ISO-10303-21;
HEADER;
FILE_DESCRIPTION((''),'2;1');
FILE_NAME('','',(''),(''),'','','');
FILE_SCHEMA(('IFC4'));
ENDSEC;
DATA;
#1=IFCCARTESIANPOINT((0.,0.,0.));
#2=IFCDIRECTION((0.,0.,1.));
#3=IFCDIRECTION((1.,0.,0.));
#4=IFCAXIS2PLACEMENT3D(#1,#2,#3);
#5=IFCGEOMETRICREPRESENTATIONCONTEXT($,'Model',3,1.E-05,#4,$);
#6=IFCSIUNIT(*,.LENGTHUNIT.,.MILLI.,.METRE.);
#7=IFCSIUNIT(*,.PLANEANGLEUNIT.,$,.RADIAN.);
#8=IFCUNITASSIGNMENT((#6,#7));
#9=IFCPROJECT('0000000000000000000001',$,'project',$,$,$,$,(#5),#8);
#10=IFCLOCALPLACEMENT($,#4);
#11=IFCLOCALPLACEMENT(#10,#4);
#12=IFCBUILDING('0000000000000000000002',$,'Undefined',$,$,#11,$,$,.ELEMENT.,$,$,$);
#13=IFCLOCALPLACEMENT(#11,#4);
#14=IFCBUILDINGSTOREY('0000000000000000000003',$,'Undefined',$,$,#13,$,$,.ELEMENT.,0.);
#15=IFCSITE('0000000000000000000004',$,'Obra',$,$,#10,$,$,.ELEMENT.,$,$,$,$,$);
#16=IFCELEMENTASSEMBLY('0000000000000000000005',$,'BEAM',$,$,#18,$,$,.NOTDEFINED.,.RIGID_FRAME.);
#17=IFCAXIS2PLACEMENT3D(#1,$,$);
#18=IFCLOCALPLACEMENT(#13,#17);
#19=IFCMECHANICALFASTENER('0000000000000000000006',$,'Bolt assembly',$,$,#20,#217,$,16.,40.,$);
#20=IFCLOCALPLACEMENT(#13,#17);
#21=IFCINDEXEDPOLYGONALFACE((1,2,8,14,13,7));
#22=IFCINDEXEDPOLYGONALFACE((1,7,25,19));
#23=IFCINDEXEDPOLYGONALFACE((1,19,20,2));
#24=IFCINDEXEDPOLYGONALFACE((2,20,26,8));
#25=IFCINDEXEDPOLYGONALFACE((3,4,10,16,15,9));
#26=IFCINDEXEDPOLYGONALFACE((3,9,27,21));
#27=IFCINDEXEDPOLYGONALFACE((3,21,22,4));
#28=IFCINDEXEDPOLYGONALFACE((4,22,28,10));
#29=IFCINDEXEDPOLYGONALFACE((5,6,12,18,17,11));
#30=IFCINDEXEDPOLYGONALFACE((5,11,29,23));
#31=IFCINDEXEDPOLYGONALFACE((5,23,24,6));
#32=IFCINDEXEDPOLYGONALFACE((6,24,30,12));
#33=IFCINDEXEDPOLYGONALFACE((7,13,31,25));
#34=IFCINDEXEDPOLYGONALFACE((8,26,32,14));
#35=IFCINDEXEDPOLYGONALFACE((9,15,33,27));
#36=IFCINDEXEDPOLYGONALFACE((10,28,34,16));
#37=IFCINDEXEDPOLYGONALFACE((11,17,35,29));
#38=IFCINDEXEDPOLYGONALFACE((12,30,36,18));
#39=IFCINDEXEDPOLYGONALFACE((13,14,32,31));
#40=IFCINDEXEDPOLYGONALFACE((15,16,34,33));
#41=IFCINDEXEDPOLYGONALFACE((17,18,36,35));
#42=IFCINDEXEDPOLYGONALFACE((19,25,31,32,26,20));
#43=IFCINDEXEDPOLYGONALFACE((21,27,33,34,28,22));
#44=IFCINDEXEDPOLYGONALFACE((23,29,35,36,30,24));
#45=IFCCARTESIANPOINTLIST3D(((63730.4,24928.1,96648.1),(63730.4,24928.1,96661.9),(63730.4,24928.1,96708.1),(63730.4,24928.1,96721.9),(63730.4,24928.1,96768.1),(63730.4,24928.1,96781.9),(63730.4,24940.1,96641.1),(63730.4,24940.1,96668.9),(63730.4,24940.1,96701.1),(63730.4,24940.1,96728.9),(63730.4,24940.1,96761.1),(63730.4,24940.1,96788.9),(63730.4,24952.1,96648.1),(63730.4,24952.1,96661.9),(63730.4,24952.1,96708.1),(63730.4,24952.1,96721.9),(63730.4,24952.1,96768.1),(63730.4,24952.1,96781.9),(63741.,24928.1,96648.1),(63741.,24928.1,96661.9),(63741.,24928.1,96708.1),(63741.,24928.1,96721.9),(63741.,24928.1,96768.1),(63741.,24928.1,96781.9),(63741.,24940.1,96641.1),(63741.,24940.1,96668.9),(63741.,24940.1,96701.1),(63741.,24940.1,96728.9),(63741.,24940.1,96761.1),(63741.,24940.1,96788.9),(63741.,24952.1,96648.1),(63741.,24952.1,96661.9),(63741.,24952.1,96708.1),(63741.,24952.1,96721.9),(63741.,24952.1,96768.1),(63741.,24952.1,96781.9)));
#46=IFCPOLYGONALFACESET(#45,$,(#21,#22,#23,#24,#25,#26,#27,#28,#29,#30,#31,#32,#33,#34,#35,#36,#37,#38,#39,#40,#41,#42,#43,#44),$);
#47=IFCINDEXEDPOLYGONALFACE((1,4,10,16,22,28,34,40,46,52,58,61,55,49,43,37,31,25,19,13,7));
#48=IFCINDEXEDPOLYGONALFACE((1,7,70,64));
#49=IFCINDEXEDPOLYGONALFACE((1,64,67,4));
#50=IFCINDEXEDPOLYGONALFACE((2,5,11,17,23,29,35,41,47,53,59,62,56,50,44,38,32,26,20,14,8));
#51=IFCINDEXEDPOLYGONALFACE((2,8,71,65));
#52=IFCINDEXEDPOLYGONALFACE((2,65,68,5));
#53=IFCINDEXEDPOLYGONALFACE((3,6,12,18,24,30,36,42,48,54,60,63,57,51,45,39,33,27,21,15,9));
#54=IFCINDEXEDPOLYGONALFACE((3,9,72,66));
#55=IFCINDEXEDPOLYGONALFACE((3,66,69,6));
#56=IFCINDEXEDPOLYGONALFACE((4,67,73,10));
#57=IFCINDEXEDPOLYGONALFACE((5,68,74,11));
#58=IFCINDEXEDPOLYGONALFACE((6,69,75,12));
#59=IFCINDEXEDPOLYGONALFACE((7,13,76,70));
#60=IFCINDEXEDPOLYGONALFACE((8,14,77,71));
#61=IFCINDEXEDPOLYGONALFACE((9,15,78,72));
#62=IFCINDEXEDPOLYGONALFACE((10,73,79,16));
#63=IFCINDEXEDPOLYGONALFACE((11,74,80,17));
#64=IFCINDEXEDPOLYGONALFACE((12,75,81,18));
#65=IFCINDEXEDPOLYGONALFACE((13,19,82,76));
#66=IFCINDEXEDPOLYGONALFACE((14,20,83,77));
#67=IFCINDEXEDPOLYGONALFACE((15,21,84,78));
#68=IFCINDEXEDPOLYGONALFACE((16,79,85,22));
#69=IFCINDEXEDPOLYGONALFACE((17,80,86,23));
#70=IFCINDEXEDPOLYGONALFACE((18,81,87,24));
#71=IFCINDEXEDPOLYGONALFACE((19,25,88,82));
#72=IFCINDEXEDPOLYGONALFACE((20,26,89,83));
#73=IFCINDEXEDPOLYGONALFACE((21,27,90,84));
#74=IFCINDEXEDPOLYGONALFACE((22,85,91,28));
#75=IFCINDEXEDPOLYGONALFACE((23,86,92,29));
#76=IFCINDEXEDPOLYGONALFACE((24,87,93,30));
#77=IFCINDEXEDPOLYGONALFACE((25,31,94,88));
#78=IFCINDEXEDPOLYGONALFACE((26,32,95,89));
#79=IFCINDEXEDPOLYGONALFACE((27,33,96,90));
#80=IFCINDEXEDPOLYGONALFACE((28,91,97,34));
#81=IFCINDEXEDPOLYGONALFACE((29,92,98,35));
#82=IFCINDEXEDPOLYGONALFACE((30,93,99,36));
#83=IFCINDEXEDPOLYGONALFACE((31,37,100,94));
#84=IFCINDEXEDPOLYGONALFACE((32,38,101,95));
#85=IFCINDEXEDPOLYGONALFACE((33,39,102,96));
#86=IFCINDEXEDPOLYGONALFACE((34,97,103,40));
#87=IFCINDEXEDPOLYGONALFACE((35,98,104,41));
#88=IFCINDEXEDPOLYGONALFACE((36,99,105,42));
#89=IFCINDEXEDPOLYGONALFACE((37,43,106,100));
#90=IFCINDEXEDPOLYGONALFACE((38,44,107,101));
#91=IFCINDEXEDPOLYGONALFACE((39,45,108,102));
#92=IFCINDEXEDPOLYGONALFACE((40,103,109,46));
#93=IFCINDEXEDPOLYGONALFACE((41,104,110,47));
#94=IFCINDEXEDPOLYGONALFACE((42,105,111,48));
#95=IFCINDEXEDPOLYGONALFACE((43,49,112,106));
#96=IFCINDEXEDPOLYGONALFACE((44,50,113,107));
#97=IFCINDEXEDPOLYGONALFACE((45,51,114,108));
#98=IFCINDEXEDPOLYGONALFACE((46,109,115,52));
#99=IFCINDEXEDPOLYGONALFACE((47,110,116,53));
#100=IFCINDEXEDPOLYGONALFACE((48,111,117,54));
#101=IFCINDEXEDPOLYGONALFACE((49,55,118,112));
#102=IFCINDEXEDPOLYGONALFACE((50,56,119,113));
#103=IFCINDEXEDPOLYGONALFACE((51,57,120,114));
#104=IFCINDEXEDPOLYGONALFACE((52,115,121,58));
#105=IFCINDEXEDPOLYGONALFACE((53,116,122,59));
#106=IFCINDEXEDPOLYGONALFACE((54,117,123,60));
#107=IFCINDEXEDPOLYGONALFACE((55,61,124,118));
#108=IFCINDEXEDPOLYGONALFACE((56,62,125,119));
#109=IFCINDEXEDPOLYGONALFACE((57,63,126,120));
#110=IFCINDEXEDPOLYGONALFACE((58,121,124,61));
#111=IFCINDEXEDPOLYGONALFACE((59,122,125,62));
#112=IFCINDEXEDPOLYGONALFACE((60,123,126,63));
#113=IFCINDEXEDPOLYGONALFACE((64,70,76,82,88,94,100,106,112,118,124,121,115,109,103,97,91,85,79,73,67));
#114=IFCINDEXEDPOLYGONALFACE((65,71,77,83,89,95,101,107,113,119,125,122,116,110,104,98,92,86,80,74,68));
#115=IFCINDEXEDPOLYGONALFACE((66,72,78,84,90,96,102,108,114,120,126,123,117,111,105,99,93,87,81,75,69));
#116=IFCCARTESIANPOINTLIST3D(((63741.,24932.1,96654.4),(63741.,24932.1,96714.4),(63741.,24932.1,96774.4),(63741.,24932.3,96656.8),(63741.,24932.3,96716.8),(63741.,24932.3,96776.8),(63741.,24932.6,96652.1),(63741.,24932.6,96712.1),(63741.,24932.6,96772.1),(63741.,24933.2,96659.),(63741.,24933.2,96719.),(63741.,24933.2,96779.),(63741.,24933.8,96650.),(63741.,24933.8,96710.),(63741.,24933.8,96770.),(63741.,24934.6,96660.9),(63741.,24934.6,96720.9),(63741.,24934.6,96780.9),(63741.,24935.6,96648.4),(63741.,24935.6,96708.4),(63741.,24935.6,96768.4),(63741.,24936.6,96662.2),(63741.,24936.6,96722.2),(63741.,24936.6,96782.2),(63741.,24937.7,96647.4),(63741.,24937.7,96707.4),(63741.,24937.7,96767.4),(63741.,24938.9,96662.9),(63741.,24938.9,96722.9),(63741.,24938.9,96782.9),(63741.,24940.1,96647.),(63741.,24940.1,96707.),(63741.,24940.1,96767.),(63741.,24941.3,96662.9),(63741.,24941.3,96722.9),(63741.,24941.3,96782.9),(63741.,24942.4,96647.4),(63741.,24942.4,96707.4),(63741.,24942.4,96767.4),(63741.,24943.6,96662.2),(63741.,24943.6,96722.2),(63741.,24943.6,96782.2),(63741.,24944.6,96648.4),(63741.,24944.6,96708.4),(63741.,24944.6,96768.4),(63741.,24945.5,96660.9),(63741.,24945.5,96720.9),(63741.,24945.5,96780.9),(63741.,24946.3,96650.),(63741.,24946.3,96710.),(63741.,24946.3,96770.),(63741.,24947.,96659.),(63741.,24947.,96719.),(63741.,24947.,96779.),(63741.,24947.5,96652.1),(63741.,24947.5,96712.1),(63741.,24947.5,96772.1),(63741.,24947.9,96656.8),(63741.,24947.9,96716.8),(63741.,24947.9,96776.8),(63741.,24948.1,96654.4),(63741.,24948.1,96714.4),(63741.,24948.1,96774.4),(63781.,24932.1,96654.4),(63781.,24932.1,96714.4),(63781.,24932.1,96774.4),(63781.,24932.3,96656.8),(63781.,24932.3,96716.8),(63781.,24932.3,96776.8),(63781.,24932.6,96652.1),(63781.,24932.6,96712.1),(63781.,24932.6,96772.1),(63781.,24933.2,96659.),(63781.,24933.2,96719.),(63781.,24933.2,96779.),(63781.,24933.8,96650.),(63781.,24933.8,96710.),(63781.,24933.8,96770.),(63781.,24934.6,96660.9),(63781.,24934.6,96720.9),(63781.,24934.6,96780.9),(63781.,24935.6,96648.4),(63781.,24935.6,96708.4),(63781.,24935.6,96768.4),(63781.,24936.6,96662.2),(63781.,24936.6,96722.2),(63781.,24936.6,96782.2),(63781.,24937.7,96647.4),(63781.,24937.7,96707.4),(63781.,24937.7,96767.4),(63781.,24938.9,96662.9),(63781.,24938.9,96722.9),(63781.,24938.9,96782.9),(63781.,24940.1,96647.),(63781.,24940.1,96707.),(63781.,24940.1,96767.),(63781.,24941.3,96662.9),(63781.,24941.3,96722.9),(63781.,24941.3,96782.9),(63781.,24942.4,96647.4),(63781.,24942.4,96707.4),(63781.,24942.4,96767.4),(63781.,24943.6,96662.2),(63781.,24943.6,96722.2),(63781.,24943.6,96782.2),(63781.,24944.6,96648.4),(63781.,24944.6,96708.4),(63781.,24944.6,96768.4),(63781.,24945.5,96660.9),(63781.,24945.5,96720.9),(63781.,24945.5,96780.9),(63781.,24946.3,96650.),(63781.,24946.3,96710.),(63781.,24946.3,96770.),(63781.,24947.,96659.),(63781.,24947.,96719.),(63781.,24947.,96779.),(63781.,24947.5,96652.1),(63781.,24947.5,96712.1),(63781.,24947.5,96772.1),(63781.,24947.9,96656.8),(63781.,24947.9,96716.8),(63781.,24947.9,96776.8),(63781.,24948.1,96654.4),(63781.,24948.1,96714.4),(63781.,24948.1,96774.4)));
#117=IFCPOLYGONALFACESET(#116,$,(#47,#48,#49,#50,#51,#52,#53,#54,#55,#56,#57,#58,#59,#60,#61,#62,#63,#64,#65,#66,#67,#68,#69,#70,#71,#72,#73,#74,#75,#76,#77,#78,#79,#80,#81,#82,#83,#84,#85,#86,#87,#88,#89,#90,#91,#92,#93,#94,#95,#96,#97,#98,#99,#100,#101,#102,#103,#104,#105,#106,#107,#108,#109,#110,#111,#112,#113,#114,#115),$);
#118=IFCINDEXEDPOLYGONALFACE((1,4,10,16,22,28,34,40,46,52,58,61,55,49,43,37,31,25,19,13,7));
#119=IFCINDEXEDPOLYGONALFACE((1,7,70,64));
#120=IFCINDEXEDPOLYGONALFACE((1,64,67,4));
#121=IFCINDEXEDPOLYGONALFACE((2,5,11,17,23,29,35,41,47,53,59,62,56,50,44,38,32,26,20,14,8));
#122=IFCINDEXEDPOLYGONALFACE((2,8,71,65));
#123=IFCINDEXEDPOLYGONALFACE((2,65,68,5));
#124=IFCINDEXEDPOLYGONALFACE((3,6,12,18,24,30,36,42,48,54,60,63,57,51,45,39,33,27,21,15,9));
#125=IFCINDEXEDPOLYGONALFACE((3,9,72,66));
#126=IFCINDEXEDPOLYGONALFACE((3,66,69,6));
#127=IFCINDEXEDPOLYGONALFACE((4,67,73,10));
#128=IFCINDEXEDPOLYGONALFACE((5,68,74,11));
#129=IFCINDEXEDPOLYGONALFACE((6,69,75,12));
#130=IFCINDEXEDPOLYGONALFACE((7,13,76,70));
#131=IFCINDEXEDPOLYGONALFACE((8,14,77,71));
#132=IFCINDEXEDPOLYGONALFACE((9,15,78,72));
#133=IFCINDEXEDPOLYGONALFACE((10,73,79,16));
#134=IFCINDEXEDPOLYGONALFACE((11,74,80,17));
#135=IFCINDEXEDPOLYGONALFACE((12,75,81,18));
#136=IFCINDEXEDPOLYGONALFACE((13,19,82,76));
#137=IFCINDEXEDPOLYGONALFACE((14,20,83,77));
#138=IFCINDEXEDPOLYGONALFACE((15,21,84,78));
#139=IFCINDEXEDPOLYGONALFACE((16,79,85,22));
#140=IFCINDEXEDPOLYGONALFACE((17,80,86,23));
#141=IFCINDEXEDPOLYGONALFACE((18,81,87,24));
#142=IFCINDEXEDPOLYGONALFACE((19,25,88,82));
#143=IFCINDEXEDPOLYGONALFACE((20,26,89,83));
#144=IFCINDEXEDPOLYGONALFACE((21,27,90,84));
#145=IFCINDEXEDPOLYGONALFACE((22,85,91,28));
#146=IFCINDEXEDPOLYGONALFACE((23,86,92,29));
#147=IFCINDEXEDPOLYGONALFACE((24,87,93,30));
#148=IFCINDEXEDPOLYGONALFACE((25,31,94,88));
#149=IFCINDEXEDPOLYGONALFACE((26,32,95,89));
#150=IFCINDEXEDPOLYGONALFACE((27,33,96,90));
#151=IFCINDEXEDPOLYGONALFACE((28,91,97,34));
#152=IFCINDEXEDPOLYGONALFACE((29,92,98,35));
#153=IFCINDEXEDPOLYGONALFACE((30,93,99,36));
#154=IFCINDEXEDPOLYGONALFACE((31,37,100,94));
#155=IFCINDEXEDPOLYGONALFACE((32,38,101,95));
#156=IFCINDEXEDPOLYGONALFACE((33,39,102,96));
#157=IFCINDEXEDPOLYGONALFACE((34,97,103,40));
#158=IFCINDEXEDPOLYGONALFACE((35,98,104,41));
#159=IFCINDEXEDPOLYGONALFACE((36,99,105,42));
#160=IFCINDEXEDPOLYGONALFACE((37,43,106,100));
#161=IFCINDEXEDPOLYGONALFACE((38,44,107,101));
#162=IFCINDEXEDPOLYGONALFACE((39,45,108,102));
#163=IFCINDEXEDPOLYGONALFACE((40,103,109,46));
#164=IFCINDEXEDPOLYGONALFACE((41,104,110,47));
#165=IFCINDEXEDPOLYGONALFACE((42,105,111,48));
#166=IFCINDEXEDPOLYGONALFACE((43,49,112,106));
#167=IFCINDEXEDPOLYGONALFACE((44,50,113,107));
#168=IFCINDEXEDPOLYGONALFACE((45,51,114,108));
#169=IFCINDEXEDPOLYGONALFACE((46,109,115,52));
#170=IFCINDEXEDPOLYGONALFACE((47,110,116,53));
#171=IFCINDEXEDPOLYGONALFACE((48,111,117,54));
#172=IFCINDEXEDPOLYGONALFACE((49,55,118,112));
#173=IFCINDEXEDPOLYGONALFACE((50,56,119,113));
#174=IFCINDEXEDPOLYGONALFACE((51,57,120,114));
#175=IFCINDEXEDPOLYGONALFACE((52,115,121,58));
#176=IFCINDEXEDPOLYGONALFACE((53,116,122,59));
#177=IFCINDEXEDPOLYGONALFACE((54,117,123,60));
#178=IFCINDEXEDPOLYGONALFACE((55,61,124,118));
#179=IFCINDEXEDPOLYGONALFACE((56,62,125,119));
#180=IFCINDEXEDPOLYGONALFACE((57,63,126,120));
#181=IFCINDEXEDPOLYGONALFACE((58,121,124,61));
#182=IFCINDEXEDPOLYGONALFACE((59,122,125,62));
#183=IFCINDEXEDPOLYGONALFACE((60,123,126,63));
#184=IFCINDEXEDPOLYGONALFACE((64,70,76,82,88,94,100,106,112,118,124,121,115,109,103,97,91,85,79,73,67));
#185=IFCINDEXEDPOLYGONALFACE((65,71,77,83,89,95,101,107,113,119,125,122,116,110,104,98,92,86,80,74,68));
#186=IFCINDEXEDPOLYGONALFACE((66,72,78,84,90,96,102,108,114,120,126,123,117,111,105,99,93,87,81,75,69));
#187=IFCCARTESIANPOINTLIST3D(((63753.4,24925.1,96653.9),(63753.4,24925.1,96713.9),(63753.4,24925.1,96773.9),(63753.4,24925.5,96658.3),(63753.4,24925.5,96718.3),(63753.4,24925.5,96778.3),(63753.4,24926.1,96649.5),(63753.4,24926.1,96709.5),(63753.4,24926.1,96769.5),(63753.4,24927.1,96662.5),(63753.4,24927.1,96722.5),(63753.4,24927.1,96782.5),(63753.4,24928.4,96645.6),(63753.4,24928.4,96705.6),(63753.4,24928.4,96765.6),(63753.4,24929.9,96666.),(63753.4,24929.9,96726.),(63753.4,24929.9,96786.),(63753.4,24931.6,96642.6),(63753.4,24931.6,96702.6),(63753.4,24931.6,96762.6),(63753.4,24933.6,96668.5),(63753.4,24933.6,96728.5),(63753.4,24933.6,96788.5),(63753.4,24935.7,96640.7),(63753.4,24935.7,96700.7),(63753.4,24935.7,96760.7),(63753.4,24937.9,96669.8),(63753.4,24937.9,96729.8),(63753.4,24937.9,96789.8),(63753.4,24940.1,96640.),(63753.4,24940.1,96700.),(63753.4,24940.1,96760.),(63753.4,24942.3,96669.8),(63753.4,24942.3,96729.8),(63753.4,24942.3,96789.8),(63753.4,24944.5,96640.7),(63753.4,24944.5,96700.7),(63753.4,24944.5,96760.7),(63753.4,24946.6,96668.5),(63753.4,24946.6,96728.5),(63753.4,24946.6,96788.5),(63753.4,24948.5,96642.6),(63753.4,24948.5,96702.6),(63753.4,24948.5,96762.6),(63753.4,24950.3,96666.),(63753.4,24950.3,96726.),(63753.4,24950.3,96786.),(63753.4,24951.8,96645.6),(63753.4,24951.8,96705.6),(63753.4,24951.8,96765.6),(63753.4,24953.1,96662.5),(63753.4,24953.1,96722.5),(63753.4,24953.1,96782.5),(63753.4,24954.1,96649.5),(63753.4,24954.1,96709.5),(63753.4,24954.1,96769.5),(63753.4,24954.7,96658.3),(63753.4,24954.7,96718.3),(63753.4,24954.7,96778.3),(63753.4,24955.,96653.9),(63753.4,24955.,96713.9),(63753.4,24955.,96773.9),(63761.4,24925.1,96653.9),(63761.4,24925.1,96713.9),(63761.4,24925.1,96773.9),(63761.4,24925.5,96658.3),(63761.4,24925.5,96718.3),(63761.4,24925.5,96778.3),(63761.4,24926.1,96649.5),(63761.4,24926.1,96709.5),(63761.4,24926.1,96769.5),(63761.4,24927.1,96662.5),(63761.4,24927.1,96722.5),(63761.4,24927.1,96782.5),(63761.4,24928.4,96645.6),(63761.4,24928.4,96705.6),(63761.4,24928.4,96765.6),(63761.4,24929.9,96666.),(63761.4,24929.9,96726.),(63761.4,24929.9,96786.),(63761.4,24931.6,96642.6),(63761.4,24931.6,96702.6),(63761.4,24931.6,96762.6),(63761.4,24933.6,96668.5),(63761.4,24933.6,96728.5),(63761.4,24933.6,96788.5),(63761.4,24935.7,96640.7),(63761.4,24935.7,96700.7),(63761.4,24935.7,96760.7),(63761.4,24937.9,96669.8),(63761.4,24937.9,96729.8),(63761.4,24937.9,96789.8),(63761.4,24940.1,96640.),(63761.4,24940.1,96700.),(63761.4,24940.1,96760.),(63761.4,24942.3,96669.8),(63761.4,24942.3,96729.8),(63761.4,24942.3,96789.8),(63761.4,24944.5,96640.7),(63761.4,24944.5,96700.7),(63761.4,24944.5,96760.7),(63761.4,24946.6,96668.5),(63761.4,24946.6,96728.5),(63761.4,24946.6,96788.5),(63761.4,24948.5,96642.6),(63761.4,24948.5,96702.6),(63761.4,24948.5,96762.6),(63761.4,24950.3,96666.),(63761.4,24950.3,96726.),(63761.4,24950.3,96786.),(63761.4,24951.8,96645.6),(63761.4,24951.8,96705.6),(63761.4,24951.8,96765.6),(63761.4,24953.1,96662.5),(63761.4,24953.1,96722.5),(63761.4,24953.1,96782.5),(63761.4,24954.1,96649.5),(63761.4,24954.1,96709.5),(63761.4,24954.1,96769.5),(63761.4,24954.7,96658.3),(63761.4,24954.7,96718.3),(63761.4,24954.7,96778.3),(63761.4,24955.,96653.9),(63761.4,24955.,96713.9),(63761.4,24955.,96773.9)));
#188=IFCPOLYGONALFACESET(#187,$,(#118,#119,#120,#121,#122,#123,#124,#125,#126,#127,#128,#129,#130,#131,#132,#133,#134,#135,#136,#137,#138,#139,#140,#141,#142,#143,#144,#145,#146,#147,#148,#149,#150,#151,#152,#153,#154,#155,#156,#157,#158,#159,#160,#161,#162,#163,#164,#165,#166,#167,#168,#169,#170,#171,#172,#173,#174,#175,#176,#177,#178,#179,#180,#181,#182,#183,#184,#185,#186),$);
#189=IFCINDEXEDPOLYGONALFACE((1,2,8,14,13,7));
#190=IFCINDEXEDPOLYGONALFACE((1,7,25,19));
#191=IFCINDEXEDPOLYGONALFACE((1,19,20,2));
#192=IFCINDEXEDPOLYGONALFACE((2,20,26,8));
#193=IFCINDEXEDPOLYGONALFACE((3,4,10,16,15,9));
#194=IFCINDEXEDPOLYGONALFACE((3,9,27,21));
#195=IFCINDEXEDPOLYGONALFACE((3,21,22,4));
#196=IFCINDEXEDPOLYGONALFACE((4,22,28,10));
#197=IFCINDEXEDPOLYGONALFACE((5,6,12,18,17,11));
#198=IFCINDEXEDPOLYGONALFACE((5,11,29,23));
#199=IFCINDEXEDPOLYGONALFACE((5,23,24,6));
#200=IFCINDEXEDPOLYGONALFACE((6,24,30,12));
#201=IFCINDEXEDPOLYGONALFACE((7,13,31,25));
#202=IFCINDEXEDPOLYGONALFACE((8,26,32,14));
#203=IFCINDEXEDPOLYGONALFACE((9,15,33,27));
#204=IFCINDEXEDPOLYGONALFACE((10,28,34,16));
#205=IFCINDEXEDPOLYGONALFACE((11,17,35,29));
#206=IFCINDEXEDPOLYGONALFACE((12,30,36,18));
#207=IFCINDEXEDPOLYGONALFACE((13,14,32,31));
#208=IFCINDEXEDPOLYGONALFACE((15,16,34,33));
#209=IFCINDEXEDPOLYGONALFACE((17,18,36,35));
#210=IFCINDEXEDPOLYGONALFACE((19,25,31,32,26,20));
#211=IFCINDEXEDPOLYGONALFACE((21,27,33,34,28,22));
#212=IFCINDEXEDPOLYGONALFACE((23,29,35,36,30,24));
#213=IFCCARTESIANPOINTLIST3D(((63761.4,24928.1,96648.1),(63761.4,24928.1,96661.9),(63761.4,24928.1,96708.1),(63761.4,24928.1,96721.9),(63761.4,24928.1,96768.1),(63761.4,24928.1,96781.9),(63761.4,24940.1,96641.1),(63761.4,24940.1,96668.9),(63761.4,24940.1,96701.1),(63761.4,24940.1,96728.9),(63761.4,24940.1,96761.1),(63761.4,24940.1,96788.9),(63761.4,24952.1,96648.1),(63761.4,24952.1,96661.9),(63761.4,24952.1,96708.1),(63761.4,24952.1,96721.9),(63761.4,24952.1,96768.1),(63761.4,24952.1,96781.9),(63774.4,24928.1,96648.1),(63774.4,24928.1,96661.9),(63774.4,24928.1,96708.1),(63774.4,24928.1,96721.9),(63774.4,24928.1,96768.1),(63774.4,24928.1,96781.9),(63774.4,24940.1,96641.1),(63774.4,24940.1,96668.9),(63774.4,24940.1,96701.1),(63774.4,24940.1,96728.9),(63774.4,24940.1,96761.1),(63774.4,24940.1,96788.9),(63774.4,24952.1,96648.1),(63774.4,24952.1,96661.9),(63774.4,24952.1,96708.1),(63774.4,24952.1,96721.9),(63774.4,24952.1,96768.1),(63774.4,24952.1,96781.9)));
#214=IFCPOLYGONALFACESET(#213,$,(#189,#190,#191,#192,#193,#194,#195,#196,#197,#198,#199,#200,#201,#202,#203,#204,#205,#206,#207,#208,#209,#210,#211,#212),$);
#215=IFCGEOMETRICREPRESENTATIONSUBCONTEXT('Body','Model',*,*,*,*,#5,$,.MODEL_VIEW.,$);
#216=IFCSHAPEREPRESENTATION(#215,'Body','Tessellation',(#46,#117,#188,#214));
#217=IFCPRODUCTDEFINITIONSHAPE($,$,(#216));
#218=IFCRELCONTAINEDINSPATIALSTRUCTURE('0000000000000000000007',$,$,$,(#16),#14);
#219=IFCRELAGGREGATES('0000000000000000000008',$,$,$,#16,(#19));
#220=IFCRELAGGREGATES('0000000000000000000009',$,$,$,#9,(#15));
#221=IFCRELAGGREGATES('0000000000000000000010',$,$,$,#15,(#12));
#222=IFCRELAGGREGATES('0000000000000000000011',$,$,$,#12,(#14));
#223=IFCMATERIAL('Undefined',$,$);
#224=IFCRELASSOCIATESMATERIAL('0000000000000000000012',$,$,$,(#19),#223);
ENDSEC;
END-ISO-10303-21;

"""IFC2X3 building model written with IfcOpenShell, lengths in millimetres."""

from ifc_helpers import new_model, si_unit, frame, origin_with_axes, origin_2d_with_axis, place, context, subcontext, project, spatial, polyline, circle, outline, extrude, source, transform, mapped, material, element, aggregate, save


model = new_model("IFC2X3")

# Units and contexts
model_context = context("Model", 3, precision=1e-05, world=origin_with_axes())
body_context = subcontext(model_context, "Body", "Model", "MODEL_VIEW")
ifc_project = project(units=[si_unit("LENGTHUNIT", "METRE", prefix="MILLI"), si_unit("PLANEANGLEUNIT", "RADIAN")], contexts=[model_context])

# Site, building, storey
site_placement = place(None, origin_with_axes())
site = spatial("IfcSite", under=ifc_project, at=site_placement, Name="Obra", CompositionType="ELEMENT")
building_placement = place(site_placement, origin_with_axes())
building = spatial("IfcBuilding", under=site, at=building_placement, Name="Undefined", CompositionType="ELEMENT")
storey_placement = place(building_placement, origin_with_axes())
storey = spatial("IfcBuildingStorey", under=building, at=storey_placement, Name="Undefined", CompositionType="ELEMENT", Elevation=0.0)

# Shared definitions
ifc_material_1 = material(Name="Undefined")

# Element assembly, mechanical fastener
assembly_1_placement = place(storey_placement, origin_with_axes())
assembly_1 = element("IfcElementAssembly", 1, at=assembly_1_placement, inside=storey, Name="BEAM", AssemblyPlace="NOTDEFINED", PredefinedType="RIGID_FRAME")
shared_shape_1 = source(origin_with_axes(), body_context, "Body", "SweptSolid", [
    extrude(outline(polyline([(13.9, 0.0), (6.9, 12.0), (-6.9, 12.0), (-13.9, 0.0), (-6.9, -12.0), (6.9, -12.0), (13.9, 0.0)])), frame((0.0, -19.7, 0.0), z_axis=(0.0, 1.0, 0.0), x_axis=(1.0, 0.0, 0.0)), (0.0, 0.0, 1.0), 10.6),
    extrude(circle(Radius=8.0, at=origin_2d_with_axis()), frame((0.0, -9.1, 0.0), z_axis=(0.0, 1.0, 0.0), x_axis=(1.0, 0.0, 0.0)), (0.0, 0.0, 1.0), 40.0),
    extrude(circle(Radius=15.0, at=origin_2d_with_axis()), frame((0.0, 3.3, 0.0), z_axis=(0.0, 1.0, 0.0), x_axis=(1.0, 0.0, 0.0)), (0.0, 0.0, 1.0), 8.0),
    extrude(outline(polyline([(13.9, 0.0), (6.9, 12.0), (-6.9, 12.0), (-13.9, 0.0), (-6.9, -12.0), (6.9, -12.0), (13.9, 0.0)])), frame((0.0, 11.3, 0.0), z_axis=(0.0, 1.0, 0.0), x_axis=(1.0, 0.0, 0.0)), (0.0, 0.0, 1.0), 13.0),
])
mechanical_fastener_1_placement = place(assembly_1_placement, frame((63750.1, 24990.1, 96835.0), z_axis=(0.000002, -1.0, 0.0), x_axis=(0.0, 0.0, -1.0)))
mechanical_fastener_1 = element("IfcMechanicalFastener", 2, at=mechanical_fastener_1_placement, material=ifc_material_1, Name="Bolt assembly", NominalDiameter=16.0, NominalLength=40.0, context=body_context, shape_type="MappedRepresentation", body=[
    mapped(shared_shape_1, transform((60.0, 0.0, 50.0))),
    mapped(shared_shape_1, transform((120.0, 0.0, 50.0))),
    mapped(shared_shape_1, transform((180.0, 0.0, 50.0))),
])

aggregate(assembly_1, [mechanical_fastener_1])

save(model, "model.ifc")
